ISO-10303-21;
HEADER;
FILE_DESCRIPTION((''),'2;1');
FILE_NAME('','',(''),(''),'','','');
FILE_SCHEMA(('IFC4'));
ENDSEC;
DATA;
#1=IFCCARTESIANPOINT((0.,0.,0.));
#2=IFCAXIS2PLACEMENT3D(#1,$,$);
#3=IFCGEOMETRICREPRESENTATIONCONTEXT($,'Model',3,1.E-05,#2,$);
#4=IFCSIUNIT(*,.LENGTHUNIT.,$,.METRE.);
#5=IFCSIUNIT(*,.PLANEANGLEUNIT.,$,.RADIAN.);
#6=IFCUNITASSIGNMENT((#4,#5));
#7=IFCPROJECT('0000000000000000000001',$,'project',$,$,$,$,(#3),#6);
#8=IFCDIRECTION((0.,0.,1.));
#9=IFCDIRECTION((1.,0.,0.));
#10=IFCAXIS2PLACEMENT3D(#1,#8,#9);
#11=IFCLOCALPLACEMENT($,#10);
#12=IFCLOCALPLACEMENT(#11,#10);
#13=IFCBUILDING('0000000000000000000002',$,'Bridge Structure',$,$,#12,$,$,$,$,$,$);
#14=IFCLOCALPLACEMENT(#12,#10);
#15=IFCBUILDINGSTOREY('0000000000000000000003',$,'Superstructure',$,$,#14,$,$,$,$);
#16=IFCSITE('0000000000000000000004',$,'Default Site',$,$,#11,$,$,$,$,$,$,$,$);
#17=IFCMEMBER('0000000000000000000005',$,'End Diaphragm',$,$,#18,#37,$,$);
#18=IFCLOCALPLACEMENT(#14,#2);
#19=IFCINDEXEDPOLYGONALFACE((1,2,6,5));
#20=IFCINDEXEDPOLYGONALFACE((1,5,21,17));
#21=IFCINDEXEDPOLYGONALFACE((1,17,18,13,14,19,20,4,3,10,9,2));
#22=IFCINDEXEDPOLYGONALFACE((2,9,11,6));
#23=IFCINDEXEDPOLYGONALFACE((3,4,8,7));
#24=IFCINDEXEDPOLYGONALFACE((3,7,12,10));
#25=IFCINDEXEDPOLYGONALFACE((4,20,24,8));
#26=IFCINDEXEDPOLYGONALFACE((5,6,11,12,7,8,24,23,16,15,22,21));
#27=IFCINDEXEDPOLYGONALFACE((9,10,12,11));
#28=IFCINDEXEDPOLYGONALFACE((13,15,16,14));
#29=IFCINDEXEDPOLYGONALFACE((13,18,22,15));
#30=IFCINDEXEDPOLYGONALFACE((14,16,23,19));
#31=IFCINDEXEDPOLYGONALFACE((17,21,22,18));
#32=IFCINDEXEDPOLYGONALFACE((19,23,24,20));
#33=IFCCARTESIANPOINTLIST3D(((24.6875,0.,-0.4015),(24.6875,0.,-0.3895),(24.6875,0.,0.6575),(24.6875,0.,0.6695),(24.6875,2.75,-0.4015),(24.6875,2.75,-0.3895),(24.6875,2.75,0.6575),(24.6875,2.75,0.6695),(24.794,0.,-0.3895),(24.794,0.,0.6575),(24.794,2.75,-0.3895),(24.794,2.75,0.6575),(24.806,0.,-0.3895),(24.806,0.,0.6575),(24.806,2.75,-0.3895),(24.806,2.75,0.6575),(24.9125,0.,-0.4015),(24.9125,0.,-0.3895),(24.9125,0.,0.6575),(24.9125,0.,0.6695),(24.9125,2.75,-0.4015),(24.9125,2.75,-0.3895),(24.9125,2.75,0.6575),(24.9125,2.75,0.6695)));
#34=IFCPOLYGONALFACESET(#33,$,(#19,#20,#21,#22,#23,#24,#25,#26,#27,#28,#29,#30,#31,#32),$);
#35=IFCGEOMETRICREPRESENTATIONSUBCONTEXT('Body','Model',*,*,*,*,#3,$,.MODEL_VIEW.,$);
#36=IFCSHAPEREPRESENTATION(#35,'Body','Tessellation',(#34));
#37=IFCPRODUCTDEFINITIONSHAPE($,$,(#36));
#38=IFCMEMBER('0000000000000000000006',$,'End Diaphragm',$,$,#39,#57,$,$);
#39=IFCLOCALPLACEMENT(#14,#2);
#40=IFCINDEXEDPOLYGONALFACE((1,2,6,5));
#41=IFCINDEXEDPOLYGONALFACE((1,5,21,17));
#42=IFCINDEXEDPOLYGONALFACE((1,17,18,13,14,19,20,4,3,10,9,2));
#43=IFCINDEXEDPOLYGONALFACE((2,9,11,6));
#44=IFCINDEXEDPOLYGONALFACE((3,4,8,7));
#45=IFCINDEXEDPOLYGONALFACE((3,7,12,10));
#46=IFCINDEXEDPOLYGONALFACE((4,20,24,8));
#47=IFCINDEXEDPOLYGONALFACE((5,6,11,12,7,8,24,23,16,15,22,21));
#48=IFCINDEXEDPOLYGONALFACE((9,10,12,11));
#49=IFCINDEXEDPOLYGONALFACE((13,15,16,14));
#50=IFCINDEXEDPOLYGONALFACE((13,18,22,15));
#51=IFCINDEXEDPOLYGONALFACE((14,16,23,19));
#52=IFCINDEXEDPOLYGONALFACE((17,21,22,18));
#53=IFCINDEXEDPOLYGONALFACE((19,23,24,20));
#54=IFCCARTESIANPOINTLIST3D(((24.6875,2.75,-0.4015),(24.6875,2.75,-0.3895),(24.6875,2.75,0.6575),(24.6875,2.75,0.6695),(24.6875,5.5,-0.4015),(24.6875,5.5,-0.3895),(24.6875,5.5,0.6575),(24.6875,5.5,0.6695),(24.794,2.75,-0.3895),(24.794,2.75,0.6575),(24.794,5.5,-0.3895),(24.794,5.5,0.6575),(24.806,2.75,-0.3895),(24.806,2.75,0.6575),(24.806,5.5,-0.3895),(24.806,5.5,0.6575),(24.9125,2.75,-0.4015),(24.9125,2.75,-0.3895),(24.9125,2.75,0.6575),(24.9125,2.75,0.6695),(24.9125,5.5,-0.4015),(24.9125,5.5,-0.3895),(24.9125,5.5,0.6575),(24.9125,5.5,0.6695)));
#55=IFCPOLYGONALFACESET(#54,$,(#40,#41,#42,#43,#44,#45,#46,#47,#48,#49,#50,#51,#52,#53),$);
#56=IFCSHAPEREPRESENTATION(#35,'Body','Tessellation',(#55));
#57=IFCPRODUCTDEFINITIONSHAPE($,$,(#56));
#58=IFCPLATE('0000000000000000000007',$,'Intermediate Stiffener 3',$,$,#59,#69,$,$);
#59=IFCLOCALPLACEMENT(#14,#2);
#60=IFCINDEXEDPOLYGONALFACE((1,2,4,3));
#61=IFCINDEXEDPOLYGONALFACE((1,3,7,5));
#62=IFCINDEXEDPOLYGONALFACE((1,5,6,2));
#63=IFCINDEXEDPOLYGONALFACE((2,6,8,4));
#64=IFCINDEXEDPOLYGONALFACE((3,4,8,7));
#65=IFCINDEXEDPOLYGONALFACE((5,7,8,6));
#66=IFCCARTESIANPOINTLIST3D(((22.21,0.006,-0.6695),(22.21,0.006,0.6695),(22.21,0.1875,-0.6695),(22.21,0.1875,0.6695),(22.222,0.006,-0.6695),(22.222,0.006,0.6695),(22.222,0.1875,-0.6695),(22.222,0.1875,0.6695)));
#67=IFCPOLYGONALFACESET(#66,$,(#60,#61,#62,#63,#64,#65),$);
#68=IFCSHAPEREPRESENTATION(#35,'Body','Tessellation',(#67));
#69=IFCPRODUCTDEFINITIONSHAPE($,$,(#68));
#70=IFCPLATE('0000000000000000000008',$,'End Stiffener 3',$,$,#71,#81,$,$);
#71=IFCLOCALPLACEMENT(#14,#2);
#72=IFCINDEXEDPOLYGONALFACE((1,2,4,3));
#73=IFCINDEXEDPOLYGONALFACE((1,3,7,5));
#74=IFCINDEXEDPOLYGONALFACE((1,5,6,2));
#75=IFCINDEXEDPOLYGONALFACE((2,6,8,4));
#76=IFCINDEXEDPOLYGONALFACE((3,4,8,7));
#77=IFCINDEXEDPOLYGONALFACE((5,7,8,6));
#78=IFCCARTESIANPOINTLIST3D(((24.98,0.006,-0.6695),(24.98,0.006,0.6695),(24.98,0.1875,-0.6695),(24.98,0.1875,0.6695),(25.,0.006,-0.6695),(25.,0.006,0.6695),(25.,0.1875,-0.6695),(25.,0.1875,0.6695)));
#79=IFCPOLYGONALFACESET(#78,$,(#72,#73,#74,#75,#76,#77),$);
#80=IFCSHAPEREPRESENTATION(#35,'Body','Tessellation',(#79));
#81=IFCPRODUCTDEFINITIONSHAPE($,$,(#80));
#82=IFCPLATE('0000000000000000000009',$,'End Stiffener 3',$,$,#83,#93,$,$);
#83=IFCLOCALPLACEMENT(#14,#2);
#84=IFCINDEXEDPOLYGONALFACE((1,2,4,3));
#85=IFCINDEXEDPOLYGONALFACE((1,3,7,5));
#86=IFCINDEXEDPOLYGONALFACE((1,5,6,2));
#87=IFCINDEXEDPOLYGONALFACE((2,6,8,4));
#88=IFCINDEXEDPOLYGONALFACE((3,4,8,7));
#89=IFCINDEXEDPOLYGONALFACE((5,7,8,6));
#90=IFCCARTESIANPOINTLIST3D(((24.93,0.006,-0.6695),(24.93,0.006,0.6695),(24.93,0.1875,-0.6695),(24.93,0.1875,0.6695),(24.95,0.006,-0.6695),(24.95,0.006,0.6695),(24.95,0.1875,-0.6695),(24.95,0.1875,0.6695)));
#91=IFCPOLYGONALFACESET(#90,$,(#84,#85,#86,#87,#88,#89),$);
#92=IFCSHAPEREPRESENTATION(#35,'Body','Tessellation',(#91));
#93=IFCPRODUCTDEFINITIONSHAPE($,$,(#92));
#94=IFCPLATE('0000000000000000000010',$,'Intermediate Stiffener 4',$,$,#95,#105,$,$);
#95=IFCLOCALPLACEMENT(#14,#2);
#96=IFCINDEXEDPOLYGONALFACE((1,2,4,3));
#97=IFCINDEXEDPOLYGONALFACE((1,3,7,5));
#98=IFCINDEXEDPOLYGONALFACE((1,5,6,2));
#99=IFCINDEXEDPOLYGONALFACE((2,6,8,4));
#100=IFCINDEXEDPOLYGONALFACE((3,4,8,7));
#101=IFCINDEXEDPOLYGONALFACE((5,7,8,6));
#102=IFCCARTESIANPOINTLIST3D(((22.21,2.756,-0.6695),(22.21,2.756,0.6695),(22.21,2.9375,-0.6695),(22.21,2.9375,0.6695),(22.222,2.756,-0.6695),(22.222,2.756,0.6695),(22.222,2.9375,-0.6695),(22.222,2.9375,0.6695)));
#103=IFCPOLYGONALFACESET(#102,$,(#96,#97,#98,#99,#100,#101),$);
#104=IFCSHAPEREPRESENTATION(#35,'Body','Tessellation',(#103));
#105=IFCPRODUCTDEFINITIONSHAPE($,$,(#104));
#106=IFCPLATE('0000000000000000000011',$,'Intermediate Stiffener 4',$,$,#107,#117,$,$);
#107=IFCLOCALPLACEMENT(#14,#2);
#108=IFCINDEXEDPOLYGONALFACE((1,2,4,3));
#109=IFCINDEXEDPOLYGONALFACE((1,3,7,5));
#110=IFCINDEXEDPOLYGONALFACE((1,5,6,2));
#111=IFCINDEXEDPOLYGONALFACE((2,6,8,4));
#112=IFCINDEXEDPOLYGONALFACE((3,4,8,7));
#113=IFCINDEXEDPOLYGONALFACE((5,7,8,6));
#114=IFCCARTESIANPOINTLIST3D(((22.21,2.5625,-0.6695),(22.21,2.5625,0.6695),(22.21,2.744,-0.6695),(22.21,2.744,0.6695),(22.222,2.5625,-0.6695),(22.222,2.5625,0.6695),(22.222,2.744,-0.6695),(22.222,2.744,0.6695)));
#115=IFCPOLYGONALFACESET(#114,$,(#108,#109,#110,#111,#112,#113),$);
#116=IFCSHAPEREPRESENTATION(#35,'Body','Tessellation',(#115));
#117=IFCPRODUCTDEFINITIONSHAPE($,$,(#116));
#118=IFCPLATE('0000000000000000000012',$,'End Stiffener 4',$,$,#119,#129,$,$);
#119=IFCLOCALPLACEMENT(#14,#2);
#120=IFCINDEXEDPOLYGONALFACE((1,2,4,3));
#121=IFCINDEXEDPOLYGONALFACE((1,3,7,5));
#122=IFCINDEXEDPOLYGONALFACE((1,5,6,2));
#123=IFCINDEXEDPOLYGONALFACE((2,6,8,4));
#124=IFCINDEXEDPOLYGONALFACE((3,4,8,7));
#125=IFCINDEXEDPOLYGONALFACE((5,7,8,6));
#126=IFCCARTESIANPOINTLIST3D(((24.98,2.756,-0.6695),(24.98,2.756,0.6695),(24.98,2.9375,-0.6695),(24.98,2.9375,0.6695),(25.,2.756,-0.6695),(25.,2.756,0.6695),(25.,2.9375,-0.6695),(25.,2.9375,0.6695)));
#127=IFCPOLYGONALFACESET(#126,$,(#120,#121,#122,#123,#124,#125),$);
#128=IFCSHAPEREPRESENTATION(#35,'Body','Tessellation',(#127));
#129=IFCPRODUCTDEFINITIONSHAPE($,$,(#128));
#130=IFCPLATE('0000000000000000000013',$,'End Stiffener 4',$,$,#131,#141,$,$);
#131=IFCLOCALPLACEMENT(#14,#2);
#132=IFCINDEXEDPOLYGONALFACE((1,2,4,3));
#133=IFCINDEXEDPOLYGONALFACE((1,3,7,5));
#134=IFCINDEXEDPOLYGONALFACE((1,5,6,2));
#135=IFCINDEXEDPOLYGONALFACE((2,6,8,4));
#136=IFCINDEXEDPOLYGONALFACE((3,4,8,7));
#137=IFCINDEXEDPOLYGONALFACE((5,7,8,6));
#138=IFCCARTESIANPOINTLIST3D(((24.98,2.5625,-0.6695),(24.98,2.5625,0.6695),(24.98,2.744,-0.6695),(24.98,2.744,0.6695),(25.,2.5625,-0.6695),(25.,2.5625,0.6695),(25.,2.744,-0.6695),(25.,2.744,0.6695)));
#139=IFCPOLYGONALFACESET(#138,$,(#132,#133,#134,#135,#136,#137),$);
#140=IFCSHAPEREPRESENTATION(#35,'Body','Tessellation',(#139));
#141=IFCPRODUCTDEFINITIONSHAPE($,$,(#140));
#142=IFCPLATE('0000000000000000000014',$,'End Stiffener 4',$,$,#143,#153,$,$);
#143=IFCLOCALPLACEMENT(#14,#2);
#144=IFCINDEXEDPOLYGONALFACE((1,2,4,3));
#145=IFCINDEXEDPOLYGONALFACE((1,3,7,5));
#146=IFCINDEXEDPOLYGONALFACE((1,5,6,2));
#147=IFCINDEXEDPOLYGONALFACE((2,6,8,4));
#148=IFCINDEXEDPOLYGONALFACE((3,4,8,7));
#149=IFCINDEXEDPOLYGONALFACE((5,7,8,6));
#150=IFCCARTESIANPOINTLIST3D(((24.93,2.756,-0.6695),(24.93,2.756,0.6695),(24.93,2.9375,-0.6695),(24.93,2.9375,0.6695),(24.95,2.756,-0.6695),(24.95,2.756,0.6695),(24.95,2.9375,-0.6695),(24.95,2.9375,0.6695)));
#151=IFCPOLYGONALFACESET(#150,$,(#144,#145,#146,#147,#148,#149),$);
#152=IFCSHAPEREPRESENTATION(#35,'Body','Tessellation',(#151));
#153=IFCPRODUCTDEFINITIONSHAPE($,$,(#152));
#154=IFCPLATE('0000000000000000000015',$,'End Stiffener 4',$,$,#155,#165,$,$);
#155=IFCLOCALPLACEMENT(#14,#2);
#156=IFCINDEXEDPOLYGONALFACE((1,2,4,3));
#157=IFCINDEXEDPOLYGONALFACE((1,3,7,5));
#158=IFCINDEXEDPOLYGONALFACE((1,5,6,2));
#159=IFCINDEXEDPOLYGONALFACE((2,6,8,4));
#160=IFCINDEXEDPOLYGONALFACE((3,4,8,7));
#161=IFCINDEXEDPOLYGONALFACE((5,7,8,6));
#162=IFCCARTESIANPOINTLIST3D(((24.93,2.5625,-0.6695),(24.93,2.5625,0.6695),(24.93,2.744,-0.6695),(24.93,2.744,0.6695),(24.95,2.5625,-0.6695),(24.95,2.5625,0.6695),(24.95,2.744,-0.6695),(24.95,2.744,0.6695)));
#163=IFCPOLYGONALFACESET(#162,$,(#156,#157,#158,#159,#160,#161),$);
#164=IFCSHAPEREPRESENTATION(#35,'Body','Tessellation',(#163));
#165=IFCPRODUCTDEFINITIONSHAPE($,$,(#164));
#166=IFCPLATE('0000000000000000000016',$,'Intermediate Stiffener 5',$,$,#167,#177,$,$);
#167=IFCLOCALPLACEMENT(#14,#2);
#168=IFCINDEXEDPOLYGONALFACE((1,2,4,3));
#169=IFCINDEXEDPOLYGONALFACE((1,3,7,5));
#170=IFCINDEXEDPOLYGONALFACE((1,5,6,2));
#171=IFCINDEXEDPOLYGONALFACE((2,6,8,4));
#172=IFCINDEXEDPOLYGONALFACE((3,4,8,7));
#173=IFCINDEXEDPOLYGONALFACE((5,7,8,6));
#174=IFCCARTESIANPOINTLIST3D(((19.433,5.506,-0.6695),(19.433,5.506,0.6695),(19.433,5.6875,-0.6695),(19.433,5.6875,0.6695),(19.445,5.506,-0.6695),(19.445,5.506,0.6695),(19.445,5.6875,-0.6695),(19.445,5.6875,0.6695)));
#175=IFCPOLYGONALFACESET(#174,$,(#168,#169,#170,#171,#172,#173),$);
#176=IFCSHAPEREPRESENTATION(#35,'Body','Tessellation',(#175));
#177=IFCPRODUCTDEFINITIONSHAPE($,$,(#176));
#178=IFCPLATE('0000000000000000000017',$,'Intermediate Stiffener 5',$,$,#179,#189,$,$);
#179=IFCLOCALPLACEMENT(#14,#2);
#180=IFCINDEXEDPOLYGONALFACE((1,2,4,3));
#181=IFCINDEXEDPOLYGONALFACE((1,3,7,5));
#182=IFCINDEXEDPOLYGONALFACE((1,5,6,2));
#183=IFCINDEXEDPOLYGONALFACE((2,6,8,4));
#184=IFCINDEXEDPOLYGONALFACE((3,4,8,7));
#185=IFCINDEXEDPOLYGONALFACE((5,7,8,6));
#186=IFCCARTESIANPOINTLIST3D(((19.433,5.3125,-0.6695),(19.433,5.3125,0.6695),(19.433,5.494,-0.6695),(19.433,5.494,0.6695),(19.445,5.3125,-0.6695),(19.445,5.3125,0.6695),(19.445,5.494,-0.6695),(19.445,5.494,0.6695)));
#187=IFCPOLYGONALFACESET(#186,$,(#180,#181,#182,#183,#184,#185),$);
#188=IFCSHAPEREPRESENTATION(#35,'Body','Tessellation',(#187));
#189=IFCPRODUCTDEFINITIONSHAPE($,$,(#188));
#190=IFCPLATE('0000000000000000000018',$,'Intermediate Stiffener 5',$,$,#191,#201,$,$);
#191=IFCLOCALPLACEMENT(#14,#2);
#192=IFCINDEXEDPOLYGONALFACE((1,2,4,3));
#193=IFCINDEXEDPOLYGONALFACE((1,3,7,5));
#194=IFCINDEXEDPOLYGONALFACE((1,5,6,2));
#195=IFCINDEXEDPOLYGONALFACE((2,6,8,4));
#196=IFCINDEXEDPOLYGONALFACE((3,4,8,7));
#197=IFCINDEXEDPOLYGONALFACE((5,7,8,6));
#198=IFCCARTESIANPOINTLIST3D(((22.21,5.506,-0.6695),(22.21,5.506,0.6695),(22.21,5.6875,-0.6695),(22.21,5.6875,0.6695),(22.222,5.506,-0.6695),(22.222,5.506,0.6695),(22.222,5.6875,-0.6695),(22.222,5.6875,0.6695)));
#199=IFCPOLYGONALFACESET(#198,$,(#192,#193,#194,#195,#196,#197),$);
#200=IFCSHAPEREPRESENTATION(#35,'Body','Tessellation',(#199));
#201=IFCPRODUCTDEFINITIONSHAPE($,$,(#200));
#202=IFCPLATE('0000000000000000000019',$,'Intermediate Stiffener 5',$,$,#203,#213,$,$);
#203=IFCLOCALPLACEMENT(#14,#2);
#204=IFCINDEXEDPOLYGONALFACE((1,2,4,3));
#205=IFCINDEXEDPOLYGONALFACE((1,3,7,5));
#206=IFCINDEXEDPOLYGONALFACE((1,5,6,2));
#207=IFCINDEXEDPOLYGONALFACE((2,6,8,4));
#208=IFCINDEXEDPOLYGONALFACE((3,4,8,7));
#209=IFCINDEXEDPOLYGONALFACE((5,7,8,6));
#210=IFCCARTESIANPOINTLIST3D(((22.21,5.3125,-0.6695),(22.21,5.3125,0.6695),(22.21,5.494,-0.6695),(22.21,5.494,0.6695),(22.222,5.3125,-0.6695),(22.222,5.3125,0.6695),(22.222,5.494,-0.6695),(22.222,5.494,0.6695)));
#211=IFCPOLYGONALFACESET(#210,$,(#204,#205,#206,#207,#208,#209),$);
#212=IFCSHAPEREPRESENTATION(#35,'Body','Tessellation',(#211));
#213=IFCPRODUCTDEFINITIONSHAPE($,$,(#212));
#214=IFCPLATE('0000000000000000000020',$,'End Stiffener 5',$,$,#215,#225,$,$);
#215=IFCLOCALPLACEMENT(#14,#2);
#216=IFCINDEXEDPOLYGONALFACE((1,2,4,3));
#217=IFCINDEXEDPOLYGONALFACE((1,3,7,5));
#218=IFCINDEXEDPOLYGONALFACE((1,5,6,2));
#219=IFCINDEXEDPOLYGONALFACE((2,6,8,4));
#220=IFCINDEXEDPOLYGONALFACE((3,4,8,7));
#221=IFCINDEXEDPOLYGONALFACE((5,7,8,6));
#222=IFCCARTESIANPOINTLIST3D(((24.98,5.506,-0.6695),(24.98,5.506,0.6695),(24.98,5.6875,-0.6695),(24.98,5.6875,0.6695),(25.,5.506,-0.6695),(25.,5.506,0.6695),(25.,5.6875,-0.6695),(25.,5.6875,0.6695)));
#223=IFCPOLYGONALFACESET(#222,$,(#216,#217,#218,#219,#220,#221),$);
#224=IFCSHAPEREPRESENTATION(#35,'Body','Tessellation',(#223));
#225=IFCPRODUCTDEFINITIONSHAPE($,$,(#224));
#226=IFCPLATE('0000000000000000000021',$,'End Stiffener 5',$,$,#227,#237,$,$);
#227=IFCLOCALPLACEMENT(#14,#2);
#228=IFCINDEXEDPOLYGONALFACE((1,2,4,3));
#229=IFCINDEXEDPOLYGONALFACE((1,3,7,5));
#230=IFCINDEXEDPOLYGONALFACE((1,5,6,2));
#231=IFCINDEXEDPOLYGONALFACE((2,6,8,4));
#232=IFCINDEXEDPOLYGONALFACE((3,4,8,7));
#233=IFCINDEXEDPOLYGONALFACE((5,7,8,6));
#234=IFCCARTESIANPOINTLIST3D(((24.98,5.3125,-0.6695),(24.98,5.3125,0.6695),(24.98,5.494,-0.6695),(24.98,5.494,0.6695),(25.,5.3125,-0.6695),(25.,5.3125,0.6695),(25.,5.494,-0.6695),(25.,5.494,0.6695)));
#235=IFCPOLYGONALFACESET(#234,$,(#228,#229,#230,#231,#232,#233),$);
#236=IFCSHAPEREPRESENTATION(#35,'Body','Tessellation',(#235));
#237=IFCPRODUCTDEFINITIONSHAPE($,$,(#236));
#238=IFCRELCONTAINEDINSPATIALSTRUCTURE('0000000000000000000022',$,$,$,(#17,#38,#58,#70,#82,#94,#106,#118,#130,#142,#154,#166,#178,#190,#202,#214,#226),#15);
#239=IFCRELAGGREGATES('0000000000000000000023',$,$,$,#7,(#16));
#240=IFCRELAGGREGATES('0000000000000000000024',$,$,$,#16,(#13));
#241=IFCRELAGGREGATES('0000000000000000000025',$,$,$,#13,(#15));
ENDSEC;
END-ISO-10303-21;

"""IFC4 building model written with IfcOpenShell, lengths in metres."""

from ifc_helpers import new_model, si_unit, frame, origin, origin_with_axes, origin_2d_with_axis, place, context, subcontext, project, spatial, rectangle, i_section, extrude, element, save


model = new_model("IFC4")

# Units and contexts
model_context = context("Model", 3, precision=1e-05, world=origin())
body_context = subcontext(model_context, "Body", "Model", "MODEL_VIEW")
ifc_project = project(units=[si_unit("LENGTHUNIT", "METRE"), si_unit("PLANEANGLEUNIT", "RADIAN")], contexts=[model_context])

# Site, building, storey
site_placement = place(None, origin_with_axes())
site = spatial("IfcSite", under=ifc_project, at=site_placement, Name="Default Site")
building_placement = place(site_placement, origin_with_axes())
building = spatial("IfcBuilding", under=site, at=building_placement, Name="Bridge Structure")
storey_placement = place(building_placement, origin_with_axes())
storey = spatial("IfcBuildingStorey", under=building, at=storey_placement, Name="Superstructure")

# Members
for number, where, z_axis, x_axis, name in (
    (1, (24.8, 0.0, 0.134), (0.0, 1.0, 0.0), (-1.0, 0.0, 0.0), "End Diaphragm"),
    (2, (24.8, 2.75, 0.134), (0.0, 1.0, 0.0), (-1.0, 0.0, 0.0), "End Diaphragm"),
):
    element("IfcMember", number, at=place(storey_placement, frame(where, z_axis=z_axis, x_axis=x_axis)), inside=storey, Name=name, context=body_context, shape_type="SweptSolid", body=[
        extrude(i_section(OverallWidth=0.225, OverallDepth=1.071, WebThickness=0.012, FlangeThickness=0.012, at=origin_2d_with_axis()), origin_with_axes(), (0.0, 0.0, 1.0), 2.75),
    ])

# Plates
plate_placement = place(storey_placement, frame((22.216, 0.0968, -0.6695), z_axis=(0.0, 0.0, 1.0), x_axis=(1.0, 0.0, 0.0)))
element("IfcPlate", 3, at=plate_placement, inside=storey, Name="Intermediate Stiffener 3", context=body_context, shape_type="SweptSolid", body=[
    extrude(rectangle(XDim=0.012, YDim=0.1815, at=origin_2d_with_axis()), origin_with_axes(), (0.0, 0.0, 1.0), 1.339),
])
for number, where, z_axis, x_axis, name in (
    (4, (24.99, 0.0968, -0.6695), (0.0, 0.0, 1.0), (1.0, 0.0, 0.0), "End Stiffener 3"),
    (5, (24.94, 0.0968, -0.6695), (0.0, 0.0, 1.0), (1.0, 0.0, 0.0), "End Stiffener 3"),
):
    element("IfcPlate", number, at=place(storey_placement, frame(where, z_axis=z_axis, x_axis=x_axis)), inside=storey, Name=name, context=body_context, shape_type="SweptSolid", body=[
        extrude(rectangle(XDim=0.02, YDim=0.1815, at=origin_2d_with_axis()), origin_with_axes(), (0.0, 0.0, 1.0), 1.339),
    ])
for number, where, z_axis, x_axis, name in (
    (6, (22.216, 2.8468, -0.6695), (0.0, 0.0, 1.0), (1.0, 0.0, 0.0), "Intermediate Stiffener 4"),
    (7, (22.216, 2.6532, -0.6695), (0.0, 0.0, 1.0), (1.0, 0.0, 0.0), "Intermediate Stiffener 4"),
):
    element("IfcPlate", number, at=place(storey_placement, frame(where, z_axis=z_axis, x_axis=x_axis)), inside=storey, Name=name, context=body_context, shape_type="SweptSolid", body=[
        extrude(rectangle(XDim=0.012, YDim=0.1815, at=origin_2d_with_axis()), origin_with_axes(), (0.0, 0.0, 1.0), 1.339),
    ])
for number, where, z_axis, x_axis, name in (
    (8, (24.99, 2.8468, -0.6695), (0.0, 0.0, 1.0), (1.0, 0.0, 0.0), "End Stiffener 4"),
    (9, (24.99, 2.6532, -0.6695), (0.0, 0.0, 1.0), (1.0, 0.0, 0.0), "End Stiffener 4"),
    (10, (24.94, 2.8468, -0.6695), (0.0, 0.0, 1.0), (1.0, 0.0, 0.0), "End Stiffener 4"),
    (11, (24.94, 2.6532, -0.6695), (0.0, 0.0, 1.0), (1.0, 0.0, 0.0), "End Stiffener 4"),
):
    element("IfcPlate", number, at=place(storey_placement, frame(where, z_axis=z_axis, x_axis=x_axis)), inside=storey, Name=name, context=body_context, shape_type="SweptSolid", body=[
        extrude(rectangle(XDim=0.02, YDim=0.1815, at=origin_2d_with_axis()), origin_with_axes(), (0.0, 0.0, 1.0), 1.339),
    ])
for number, where, z_axis, x_axis, name in (
    (12, (19.439, 5.5968, -0.6695), (0.0, 0.0, 1.0), (1.0, 0.0, 0.0), "Intermediate Stiffener 5"),
    (13, (19.439, 5.4032, -0.6695), (0.0, 0.0, 1.0), (1.0, 0.0, 0.0), "Intermediate Stiffener 5"),
    (14, (22.216, 5.5968, -0.6695), (0.0, 0.0, 1.0), (1.0, 0.0, 0.0), "Intermediate Stiffener 5"),
    (15, (22.216, 5.4032, -0.6695), (0.0, 0.0, 1.0), (1.0, 0.0, 0.0), "Intermediate Stiffener 5"),
):
    element("IfcPlate", number, at=place(storey_placement, frame(where, z_axis=z_axis, x_axis=x_axis)), inside=storey, Name=name, context=body_context, shape_type="SweptSolid", body=[
        extrude(rectangle(XDim=0.012, YDim=0.1815, at=origin_2d_with_axis()), origin_with_axes(), (0.0, 0.0, 1.0), 1.339),
    ])
for number, where, z_axis, x_axis, name in (
    (16, (24.99, 5.5968, -0.6695), (0.0, 0.0, 1.0), (1.0, 0.0, 0.0), "End Stiffener 5"),
    (17, (24.99, 5.4032, -0.6695), (0.0, 0.0, 1.0), (1.0, 0.0, 0.0), "End Stiffener 5"),
):
    element("IfcPlate", number, at=place(storey_placement, frame(where, z_axis=z_axis, x_axis=x_axis)), inside=storey, Name=name, context=body_context, shape_type="SweptSolid", body=[
        extrude(rectangle(XDim=0.02, YDim=0.1815, at=origin_2d_with_axis()), origin_with_axes(), (0.0, 0.0, 1.0), 1.339),
    ])

save(model, "model.ifc")
